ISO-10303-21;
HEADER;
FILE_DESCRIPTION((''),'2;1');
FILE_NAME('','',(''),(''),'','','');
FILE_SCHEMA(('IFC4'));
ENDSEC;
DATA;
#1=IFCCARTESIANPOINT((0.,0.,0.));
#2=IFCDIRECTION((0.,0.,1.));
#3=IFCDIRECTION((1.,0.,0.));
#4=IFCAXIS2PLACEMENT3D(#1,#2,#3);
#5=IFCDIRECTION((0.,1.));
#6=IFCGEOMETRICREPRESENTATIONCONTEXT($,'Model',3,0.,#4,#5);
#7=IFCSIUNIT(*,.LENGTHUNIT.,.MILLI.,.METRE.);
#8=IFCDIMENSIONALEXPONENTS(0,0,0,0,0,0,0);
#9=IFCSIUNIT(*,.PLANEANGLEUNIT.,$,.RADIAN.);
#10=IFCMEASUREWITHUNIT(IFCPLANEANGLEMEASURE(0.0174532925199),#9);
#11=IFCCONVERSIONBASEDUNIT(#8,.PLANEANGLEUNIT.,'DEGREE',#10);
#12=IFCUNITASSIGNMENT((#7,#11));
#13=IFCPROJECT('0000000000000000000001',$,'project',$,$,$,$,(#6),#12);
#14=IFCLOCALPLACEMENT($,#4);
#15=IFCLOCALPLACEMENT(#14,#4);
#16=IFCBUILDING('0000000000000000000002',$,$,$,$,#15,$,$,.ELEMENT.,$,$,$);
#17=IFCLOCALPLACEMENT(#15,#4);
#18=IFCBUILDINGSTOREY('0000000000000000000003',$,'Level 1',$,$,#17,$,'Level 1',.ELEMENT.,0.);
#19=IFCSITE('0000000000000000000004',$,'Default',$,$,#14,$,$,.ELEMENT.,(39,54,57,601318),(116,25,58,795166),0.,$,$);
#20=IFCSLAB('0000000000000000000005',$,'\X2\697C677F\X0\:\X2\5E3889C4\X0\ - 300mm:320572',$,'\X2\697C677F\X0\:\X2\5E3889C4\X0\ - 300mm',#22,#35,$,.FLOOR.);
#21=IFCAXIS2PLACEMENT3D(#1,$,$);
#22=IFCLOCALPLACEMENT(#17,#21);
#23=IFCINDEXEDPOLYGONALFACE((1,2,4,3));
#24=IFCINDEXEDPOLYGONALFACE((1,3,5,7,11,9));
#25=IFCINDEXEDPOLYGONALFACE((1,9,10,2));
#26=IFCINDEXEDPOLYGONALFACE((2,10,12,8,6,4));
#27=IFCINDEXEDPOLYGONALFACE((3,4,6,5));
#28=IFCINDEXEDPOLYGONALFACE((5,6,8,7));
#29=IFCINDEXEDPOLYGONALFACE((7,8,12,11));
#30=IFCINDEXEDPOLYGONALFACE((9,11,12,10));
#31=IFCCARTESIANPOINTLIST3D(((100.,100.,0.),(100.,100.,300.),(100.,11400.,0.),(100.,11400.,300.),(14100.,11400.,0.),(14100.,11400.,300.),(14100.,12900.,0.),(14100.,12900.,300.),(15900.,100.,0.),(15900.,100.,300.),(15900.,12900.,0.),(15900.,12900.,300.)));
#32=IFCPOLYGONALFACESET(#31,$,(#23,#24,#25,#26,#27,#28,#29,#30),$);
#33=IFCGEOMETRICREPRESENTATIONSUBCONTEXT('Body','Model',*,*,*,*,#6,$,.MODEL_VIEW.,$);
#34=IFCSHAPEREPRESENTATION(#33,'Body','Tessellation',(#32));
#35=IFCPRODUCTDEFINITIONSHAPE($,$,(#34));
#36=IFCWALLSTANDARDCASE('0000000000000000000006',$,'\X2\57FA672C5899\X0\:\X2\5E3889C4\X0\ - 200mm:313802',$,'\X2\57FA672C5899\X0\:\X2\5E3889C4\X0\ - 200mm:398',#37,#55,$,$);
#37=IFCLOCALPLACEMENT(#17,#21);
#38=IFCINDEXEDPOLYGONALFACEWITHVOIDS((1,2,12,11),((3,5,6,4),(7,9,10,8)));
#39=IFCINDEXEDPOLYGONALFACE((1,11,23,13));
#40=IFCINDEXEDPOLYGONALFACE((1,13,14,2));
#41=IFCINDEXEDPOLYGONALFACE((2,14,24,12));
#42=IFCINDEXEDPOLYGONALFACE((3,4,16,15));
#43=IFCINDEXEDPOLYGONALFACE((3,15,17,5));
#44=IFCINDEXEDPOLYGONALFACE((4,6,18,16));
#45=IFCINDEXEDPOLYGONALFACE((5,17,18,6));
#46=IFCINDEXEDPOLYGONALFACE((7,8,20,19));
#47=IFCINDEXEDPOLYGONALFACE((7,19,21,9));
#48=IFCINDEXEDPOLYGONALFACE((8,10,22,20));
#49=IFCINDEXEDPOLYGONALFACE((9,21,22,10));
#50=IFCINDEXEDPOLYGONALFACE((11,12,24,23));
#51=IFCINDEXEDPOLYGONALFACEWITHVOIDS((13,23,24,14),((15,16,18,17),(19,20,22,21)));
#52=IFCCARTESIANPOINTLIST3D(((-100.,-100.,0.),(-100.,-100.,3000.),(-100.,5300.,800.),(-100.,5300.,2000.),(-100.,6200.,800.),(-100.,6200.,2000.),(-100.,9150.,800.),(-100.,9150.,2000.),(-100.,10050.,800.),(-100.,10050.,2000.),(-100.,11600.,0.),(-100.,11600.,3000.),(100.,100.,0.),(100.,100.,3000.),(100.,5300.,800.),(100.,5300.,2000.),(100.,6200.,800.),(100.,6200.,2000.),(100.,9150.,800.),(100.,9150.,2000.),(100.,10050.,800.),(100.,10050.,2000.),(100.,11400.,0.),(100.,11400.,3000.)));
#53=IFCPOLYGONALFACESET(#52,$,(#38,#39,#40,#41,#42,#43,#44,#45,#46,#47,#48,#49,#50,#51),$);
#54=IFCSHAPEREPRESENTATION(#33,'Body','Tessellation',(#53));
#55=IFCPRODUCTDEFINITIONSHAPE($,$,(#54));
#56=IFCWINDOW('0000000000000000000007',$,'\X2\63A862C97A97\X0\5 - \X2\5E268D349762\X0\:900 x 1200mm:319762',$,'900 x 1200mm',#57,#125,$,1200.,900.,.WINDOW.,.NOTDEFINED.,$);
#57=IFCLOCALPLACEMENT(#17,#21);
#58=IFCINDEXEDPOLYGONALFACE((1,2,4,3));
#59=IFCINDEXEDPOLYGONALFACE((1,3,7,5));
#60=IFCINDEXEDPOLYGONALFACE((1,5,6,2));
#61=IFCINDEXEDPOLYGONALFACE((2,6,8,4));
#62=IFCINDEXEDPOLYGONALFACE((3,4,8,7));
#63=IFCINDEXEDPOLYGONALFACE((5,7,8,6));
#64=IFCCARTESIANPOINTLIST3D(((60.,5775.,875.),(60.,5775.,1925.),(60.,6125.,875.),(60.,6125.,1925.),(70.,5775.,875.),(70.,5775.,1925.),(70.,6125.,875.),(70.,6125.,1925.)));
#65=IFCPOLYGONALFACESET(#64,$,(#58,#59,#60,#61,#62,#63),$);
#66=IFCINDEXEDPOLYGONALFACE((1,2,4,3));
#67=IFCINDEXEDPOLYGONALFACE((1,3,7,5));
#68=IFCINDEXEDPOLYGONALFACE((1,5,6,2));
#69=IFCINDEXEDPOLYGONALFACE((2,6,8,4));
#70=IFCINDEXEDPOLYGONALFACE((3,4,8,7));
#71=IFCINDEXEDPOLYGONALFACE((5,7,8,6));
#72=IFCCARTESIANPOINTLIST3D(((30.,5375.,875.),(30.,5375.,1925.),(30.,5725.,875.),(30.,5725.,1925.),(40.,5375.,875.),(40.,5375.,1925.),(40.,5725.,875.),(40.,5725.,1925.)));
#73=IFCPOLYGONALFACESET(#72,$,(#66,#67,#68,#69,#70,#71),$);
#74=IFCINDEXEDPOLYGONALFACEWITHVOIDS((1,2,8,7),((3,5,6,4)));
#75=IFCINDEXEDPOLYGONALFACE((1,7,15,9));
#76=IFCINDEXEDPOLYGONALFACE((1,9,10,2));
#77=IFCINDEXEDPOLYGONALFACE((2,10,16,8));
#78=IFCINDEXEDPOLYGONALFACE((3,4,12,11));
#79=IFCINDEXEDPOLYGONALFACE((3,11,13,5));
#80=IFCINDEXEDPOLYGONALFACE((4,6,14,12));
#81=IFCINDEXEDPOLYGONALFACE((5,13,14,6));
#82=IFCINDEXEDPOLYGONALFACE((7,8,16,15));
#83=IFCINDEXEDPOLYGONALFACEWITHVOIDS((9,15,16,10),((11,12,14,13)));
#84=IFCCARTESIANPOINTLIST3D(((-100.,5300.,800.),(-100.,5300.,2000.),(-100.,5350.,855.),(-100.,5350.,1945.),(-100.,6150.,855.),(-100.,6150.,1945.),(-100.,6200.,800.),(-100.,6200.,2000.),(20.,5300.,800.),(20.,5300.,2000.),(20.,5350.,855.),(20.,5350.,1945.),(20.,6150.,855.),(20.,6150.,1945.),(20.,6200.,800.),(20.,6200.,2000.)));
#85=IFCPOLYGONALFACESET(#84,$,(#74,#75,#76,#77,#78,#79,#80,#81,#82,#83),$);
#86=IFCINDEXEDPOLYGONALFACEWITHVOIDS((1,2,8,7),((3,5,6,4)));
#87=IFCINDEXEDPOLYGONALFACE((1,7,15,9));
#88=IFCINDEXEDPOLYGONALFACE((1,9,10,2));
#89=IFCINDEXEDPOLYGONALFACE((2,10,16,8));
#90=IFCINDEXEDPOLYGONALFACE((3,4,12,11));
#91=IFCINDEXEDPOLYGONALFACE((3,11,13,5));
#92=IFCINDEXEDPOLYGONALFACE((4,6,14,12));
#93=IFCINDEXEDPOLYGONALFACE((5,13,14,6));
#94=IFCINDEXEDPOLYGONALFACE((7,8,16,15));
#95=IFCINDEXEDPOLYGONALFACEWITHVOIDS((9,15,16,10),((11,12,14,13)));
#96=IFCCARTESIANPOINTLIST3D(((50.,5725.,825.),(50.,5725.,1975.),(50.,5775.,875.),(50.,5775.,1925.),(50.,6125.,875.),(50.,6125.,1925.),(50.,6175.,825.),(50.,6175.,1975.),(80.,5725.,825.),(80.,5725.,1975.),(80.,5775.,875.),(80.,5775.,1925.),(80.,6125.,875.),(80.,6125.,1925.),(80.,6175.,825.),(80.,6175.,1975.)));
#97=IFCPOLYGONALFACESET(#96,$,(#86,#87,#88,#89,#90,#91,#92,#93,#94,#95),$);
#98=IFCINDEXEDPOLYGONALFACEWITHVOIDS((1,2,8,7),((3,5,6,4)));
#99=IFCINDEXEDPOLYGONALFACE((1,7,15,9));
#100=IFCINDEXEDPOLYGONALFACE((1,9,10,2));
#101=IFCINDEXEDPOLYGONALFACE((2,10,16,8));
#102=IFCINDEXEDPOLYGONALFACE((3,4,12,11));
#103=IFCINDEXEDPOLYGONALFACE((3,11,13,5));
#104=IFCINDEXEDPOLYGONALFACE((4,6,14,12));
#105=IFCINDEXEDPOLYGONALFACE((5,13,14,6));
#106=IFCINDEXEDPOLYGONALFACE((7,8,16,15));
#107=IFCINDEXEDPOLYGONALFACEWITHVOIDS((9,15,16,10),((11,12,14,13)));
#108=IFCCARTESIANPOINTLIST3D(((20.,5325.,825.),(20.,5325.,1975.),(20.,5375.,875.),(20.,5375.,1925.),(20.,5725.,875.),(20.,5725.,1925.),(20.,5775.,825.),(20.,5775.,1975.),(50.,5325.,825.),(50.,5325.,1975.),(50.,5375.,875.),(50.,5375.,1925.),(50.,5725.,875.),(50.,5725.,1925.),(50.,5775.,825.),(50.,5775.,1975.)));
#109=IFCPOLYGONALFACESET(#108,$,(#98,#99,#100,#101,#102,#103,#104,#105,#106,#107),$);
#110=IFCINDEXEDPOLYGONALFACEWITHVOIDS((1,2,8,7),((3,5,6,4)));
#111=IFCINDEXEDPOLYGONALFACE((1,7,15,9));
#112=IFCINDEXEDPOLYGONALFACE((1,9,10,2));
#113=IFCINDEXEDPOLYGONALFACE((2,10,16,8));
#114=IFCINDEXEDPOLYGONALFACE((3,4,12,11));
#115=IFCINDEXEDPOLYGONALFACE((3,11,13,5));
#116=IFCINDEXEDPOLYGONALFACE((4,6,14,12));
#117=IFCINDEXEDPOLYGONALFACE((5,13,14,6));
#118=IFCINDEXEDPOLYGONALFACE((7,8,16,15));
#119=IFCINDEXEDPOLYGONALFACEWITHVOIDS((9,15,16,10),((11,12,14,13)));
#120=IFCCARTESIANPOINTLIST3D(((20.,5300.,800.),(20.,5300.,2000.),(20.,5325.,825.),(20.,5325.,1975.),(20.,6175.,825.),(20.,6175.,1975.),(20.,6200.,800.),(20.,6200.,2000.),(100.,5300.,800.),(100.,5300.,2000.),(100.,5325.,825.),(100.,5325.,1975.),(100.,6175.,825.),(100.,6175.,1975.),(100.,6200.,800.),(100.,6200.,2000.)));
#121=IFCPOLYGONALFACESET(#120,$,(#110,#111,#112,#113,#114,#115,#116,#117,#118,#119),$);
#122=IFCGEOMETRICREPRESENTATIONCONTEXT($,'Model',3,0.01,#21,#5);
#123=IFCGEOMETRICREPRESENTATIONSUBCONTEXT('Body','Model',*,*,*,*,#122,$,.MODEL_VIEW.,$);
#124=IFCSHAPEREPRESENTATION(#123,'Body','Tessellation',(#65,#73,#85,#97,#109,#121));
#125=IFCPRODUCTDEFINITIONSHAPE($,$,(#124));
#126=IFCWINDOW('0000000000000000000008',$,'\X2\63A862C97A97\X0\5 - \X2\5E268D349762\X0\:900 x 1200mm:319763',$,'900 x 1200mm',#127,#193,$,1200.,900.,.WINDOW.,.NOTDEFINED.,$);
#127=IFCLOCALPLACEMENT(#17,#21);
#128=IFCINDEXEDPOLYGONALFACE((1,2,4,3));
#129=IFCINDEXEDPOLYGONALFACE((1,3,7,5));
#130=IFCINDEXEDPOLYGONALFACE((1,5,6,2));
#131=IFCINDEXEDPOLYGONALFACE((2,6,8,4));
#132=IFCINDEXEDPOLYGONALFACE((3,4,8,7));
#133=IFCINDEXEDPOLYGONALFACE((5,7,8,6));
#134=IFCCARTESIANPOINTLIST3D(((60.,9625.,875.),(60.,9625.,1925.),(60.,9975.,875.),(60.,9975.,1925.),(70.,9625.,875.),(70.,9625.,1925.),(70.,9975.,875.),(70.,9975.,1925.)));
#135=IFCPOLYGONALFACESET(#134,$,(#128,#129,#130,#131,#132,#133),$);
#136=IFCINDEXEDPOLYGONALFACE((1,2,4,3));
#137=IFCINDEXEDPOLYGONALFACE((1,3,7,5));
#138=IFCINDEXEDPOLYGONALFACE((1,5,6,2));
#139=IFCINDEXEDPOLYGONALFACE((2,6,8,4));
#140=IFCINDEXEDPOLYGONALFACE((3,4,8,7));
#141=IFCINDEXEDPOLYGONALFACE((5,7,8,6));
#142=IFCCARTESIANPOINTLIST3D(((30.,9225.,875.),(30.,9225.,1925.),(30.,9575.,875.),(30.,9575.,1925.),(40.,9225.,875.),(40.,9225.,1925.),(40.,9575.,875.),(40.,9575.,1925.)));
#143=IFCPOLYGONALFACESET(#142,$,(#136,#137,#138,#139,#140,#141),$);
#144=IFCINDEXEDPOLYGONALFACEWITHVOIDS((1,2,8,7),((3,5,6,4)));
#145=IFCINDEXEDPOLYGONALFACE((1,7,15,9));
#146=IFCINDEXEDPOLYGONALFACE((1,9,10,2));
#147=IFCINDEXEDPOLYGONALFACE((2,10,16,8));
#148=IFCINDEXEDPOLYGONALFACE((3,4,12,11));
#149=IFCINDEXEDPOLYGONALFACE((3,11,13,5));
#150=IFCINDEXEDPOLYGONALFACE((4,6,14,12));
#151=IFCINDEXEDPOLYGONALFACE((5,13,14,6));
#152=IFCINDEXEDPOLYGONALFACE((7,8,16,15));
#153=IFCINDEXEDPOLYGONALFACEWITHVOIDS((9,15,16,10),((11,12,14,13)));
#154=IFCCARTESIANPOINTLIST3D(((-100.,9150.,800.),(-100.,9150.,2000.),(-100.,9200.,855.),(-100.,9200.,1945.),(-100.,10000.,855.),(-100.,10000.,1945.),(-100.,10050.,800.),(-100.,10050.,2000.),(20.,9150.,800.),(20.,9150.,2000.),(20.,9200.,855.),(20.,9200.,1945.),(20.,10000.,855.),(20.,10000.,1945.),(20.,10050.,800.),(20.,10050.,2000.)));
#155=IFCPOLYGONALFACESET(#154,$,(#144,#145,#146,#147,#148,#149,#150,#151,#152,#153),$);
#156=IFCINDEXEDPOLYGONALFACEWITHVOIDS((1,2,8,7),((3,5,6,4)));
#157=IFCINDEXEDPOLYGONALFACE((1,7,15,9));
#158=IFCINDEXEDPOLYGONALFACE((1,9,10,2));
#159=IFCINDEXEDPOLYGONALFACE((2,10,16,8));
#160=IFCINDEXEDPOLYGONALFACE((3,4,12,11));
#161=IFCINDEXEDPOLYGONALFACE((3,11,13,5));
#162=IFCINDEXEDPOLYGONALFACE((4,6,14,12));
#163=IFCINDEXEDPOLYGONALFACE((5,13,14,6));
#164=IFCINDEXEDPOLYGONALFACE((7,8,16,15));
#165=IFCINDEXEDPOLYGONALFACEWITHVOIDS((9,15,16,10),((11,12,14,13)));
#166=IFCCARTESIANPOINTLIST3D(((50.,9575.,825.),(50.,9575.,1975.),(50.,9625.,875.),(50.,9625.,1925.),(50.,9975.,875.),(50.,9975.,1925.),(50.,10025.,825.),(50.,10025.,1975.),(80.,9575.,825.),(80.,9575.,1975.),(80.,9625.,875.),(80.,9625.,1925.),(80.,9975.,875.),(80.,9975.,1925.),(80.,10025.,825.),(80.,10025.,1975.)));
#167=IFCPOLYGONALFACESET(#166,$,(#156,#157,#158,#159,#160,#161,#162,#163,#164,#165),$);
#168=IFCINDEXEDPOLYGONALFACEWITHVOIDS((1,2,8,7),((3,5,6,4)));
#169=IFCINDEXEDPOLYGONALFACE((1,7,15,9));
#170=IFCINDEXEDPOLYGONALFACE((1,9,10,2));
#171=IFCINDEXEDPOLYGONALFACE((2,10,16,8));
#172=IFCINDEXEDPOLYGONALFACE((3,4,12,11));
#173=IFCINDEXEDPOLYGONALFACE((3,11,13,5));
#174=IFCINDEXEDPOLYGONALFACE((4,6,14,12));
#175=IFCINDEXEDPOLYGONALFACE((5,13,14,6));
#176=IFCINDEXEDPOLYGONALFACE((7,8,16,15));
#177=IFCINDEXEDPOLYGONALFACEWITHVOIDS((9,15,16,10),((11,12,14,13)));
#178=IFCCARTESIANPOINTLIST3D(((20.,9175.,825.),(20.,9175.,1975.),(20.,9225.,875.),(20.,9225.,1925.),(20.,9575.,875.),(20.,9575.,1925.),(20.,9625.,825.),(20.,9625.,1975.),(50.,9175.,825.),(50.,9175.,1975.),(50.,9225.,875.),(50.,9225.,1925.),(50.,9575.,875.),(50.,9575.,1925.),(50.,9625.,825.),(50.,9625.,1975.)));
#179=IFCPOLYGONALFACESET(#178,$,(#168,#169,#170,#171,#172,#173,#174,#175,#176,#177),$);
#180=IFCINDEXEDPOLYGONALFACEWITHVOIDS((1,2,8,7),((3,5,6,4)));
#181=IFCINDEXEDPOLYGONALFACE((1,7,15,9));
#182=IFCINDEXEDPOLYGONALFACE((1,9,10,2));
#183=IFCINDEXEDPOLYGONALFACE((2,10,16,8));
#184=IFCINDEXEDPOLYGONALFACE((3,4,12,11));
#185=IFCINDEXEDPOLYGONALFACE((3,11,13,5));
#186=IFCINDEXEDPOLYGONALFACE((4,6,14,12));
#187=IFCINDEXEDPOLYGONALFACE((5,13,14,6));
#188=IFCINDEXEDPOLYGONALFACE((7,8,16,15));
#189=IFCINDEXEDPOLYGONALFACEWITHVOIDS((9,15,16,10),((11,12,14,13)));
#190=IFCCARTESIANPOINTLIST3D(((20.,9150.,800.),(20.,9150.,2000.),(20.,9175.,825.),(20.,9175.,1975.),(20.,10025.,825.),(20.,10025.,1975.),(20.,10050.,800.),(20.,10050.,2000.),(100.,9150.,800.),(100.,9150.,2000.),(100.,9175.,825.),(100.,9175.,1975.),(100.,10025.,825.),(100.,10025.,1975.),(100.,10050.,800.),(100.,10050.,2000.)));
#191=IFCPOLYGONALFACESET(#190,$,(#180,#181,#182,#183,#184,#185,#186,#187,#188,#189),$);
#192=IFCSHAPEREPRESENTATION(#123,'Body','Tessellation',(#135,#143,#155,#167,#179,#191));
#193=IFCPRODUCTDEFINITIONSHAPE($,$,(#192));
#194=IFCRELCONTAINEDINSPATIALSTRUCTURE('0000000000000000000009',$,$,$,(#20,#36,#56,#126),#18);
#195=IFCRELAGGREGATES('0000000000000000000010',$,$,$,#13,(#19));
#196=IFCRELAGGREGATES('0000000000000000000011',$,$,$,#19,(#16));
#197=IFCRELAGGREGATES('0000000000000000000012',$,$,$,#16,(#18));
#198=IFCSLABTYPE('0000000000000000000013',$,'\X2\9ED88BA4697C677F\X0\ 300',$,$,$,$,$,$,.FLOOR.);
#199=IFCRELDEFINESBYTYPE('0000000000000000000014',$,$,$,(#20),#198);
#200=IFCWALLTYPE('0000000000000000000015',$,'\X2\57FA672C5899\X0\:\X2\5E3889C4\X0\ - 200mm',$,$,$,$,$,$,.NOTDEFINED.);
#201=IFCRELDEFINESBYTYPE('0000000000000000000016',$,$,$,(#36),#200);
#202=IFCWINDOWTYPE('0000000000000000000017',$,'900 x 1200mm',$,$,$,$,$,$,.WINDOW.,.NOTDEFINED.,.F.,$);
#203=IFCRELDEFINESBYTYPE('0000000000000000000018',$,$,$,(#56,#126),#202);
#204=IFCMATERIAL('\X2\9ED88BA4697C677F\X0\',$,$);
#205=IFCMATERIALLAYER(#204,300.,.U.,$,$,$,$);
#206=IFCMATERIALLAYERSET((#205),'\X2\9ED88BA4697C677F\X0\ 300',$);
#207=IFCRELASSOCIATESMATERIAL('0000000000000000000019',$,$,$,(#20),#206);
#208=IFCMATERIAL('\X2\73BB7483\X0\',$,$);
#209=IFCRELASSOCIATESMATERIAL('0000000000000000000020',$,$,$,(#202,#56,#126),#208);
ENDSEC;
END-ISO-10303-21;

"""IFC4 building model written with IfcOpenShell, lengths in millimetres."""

from ifc_helpers import new_model, entity, si_unit, converted_unit, direction, frame, frame_2d, origin, origin_with_axes, origin_2d_with_axis, place, context, subcontext, project, spatial, polyline, rectangle, outline, extrude, source, transform, mapped, material, layer, layer_set, layer_usage, type_object, type_shapes, element, fill, save


model = new_model("IFC4")

# Units and contexts
model_context_1 = context("Model", 3, precision=0.0, world=origin_with_axes(), true_north=direction((0.0, 1.0)))
model_context_2 = context("Model", 3, precision=0.01, world=origin(), true_north=direction((0.0, 1.0)))
body_context_1 = subcontext(model_context_1, "Body", "Model", "MODEL_VIEW")
body_context_2 = subcontext(model_context_2, "Body", "Model", "MODEL_VIEW")
ifc_project = project(units=[si_unit("LENGTHUNIT", "METRE", prefix="MILLI"), converted_unit("PLANEANGLEUNIT", "DEGREE", entity("IfcPlaneAngleMeasure", 0.0174532925199), si_unit("PLANEANGLEUNIT", "RADIAN"), dimensions=[0, 0, 0, 0, 0, 0, 0])], contexts=[model_context_1])

# Site, building, storey
site_placement = place(None, origin_with_axes())
site = spatial("IfcSite", under=ifc_project, at=site_placement, Name="Default", CompositionType="ELEMENT", RefLatitude=(39, 54, 57, 601318), RefLongitude=(116, 25, 58, 795166), RefElevation=0.0)
building_placement = place(site_placement, origin_with_axes())
building = spatial("IfcBuilding", under=site, at=building_placement, CompositionType="ELEMENT")
storey_placement = place(building_placement, origin_with_axes())
storey = spatial("IfcBuildingStorey", under=building, at=storey_placement, Name="Level 1", LongName="Level 1", CompositionType="ELEMENT", Elevation=0.0)

# Slab
ifc_material_1 = material(Name="默认楼板")
ifc_layer_1 = layer(ifc_material_1, 300.0, ventilated="UNKNOWN")
ifc_layer_set_1 = layer_set([ifc_layer_1], Name="默认楼板 300")
ifc_layer_usage_1 = layer_usage(ifc_layer_set_1, "AXIS3", "NEGATIVE", 300.0)
slab_type = type_object("IfcSlabType", Name="默认楼板 300", PredefinedType="FLOOR")
slab_placement = place(storey_placement, frame((100.0, 100.0, 0.0), z_axis=(0.0, 0.0, 1.0), x_axis=(1.0, 0.0, 0.0)))
element("IfcSlab", 1, at=slab_placement, inside=storey, type_object=slab_type, material=ifc_layer_usage_1, Name="楼板:常规 - 300mm:320572", ObjectType="楼板:常规 - 300mm", PredefinedType="FLOOR", context=body_context_1, shape_type="SweptSolid", body=[
    extrude(outline(polyline([(0.0, 0.0), (15800.0, 0.0), (15800.0, 12800.0), (14000.0, 12800.0), (14000.0, 11300.0), (0.0, 11300.0), (0.0, 0.0)])), origin_with_axes(), (0.0, 0.0, 1.0), 300.0),
])

# Shared definitions
wall_type_1 = type_object("IfcWallType", Name="基本墙:常规 - 200mm", PredefinedType="NOTDEFINED")
placement_1 = place(None, origin())
placement_2 = place(placement_1, origin())
placement_3 = place(placement_2, origin())
ifc_material_2 = material(Name="玻璃")

# Wall, openings, windows
wall_1_placement = place(storey_placement, frame((0.0, 0.0, 0.0), z_axis=(0.0, 0.0, 1.0), x_axis=(0.0, 1.0, 0.0)))
wall_1 = element("IfcWallStandardCase", 2, at=wall_1_placement, inside=storey, type_object=wall_type_1, Name="基本墙:常规 - 200mm:313802", ObjectType="基本墙:常规 - 200mm:398", context=body_context_1, shape_type="SweptSolid", body=[
    extrude(outline(polyline([(100.0, -100.0), (11400.0, -100.0), (11600.0, 100.0), (-100.0, 100.0), (100.0, -100.0)])), origin_with_axes(), (0.0, 0.0, 1.0), 3000.0),
])
placement_4 = place(placement_3, frame((0.0, 100.0, 0.0), z_axis=(0.0, 0.0, 1.0), x_axis=(0.0, 1.0, 0.0)))
opening_1_placement = place(placement_4, frame((6100.0, 100.0, 800.0)))
opening_1 = element("IfcOpeningElement", 3, at=opening_1_placement, cuts=wall_1, ObjectType="Opening", PredefinedType="OPENING", context=body_context_2, shape_type="SweptSolid", body=[
    extrude(rectangle(XDim=1200.0, YDim=900.0, at=frame_2d((600.0, 450.0), x_axis=(-1.0, 0.0))), frame((0.0, 0.0, 0.0), z_axis=(0.0, -1.0, 0.0), x_axis=(0.0, 0.0, 1.0)), (0.0, 0.0, 1.0), 200.0),
])
opening_2_placement = place(placement_4, frame((9950.0, 100.0, 800.0)))
opening_2 = element("IfcOpeningElement", 4, at=opening_2_placement, cuts=wall_1, ObjectType="Opening", PredefinedType="OPENING", context=body_context_2, shape_type="SweptSolid", body=[
    extrude(rectangle(XDim=1200.0, YDim=900.0, at=frame_2d((600.0, 450.0), x_axis=(-1.0, 0.0))), frame((0.0, 0.0, 0.0), z_axis=(0.0, -1.0, 0.0), x_axis=(0.0, 0.0, 1.0)), (0.0, 0.0, 1.0), 200.0),
])
window_type_1 = type_object("IfcWindowType", Name="900 x 1200mm", ParameterTakesPrecedence=False, PartitioningType="NOTDEFINED", PredefinedType="WINDOW", material=ifc_material_2)
shared_shape_1 = source(origin(), body_context_2, "Body", "SweptSolid", [
    extrude(rectangle(XDim=10.0, YDim=350.0, at=origin_2d_with_axis()), frame((250.0, 165.0, 75.0), z_axis=(0.0, 0.0, 1.0), x_axis=(0.0, -1.0, 0.0)), (0.0, 0.0, 1.0), 1050.0),
    extrude(rectangle(XDim=10.0, YDim=350.0, at=origin_2d_with_axis()), frame((650.0, 135.0, 75.0), z_axis=(0.0, 0.0, 1.0), x_axis=(0.0, -1.0, 0.0)), (0.0, 0.0, 1.0), 1050.0),
    extrude(outline(polyline([(-450.0, -600.0), (450.0, -600.0), (450.0, 600.0), (-450.0, 600.0), (-450.0, -600.0)]), holes=[polyline([(400.0, -545.0), (-400.0, -545.0), (-400.0, 545.0), (400.0, 545.0), (400.0, -545.0)])]), frame((450.0, 0.0, 600.0), z_axis=(0.0, 1.0, 0.0), x_axis=(1.0, 0.0, 0.0)), (0.0, 0.0, 1.0), 120.0),
    extrude(outline(polyline([(-225.0, -575.0), (225.0, -575.0), (225.0, 575.0), (-225.0, 575.0), (-225.0, -575.0)]), holes=[polyline([(-175.0, -525.0), (-175.0, 525.0), (175.0, 525.0), (175.0, -525.0), (-175.0, -525.0)])]), frame((250.0, 150.0, 600.0), z_axis=(0.0, 1.0, 0.0), x_axis=(-1.0, 0.0, 0.0)), (0.0, 0.0, 1.0), 30.0),
    extrude(outline(polyline([(-225.0, -575.0), (225.0, -575.0), (225.0, 575.0), (-225.0, 575.0), (-225.0, -575.0)]), holes=[polyline([(-175.0, -525.0), (-175.0, 525.0), (175.0, 525.0), (175.0, -525.0), (-175.0, -525.0)])]), frame((650.0, 120.0, 600.0), z_axis=(0.0, 1.0, 0.0), x_axis=(1.0, 0.0, 0.0)), (0.0, 0.0, 1.0), 30.0),
    extrude(outline(polyline([(-450.0, -600.0), (450.0, -600.0), (450.0, 600.0), (-450.0, 600.0), (-450.0, -600.0)]), holes=[polyline([(-425.0, 575.0), (425.0, 575.0), (425.0, -575.0), (-425.0, -575.0), (-425.0, 575.0)])]), frame((450.0, 120.0, 600.0), z_axis=(0.0, 1.0, 0.0), x_axis=(1.0, 0.0, 0.0)), (0.0, 0.0, 1.0), 80.0),
])
type_shapes(window_type_1, [shared_shape_1])
window_1_placement = place(opening_1_placement, frame((0.0, 0.0, 0.0), z_axis=(0.0, 0.0, 1.0), x_axis=(-1.0, 0.0, 0.0)))
window_1 = element("IfcWindow", 5, at=window_1_placement, inside=storey, type_object=window_type_1, material=ifc_material_2, Name="推拉窗5 - 带贴面:900 x 1200mm:319762", ObjectType="900 x 1200mm", OverallHeight=1200.0, OverallWidth=900.0, PartitioningType="NOTDEFINED", PredefinedType="WINDOW", context=body_context_2, shape_type="MappedRepresentation", body=[
    mapped(shared_shape_1, transform((0.0, 0.0, 0.0), scale=1.0)),
])
fill(opening_1, window_1)
window_2_placement = place(opening_2_placement, frame((0.0, 0.0, 0.0), z_axis=(0.0, 0.0, 1.0), x_axis=(-1.0, 0.0, 0.0)))
window_2 = element("IfcWindow", 6, at=window_2_placement, inside=storey, type_object=window_type_1, material=ifc_material_2, Name="推拉窗5 - 带贴面:900 x 1200mm:319763", ObjectType="900 x 1200mm", OverallHeight=1200.0, OverallWidth=900.0, PartitioningType="NOTDEFINED", PredefinedType="WINDOW", context=body_context_2, shape_type="MappedRepresentation", body=[
    mapped(shared_shape_1, transform((0.0, 0.0, 0.0), scale=1.0)),
])
fill(opening_2, window_2)

save(model, "model.ifc")
